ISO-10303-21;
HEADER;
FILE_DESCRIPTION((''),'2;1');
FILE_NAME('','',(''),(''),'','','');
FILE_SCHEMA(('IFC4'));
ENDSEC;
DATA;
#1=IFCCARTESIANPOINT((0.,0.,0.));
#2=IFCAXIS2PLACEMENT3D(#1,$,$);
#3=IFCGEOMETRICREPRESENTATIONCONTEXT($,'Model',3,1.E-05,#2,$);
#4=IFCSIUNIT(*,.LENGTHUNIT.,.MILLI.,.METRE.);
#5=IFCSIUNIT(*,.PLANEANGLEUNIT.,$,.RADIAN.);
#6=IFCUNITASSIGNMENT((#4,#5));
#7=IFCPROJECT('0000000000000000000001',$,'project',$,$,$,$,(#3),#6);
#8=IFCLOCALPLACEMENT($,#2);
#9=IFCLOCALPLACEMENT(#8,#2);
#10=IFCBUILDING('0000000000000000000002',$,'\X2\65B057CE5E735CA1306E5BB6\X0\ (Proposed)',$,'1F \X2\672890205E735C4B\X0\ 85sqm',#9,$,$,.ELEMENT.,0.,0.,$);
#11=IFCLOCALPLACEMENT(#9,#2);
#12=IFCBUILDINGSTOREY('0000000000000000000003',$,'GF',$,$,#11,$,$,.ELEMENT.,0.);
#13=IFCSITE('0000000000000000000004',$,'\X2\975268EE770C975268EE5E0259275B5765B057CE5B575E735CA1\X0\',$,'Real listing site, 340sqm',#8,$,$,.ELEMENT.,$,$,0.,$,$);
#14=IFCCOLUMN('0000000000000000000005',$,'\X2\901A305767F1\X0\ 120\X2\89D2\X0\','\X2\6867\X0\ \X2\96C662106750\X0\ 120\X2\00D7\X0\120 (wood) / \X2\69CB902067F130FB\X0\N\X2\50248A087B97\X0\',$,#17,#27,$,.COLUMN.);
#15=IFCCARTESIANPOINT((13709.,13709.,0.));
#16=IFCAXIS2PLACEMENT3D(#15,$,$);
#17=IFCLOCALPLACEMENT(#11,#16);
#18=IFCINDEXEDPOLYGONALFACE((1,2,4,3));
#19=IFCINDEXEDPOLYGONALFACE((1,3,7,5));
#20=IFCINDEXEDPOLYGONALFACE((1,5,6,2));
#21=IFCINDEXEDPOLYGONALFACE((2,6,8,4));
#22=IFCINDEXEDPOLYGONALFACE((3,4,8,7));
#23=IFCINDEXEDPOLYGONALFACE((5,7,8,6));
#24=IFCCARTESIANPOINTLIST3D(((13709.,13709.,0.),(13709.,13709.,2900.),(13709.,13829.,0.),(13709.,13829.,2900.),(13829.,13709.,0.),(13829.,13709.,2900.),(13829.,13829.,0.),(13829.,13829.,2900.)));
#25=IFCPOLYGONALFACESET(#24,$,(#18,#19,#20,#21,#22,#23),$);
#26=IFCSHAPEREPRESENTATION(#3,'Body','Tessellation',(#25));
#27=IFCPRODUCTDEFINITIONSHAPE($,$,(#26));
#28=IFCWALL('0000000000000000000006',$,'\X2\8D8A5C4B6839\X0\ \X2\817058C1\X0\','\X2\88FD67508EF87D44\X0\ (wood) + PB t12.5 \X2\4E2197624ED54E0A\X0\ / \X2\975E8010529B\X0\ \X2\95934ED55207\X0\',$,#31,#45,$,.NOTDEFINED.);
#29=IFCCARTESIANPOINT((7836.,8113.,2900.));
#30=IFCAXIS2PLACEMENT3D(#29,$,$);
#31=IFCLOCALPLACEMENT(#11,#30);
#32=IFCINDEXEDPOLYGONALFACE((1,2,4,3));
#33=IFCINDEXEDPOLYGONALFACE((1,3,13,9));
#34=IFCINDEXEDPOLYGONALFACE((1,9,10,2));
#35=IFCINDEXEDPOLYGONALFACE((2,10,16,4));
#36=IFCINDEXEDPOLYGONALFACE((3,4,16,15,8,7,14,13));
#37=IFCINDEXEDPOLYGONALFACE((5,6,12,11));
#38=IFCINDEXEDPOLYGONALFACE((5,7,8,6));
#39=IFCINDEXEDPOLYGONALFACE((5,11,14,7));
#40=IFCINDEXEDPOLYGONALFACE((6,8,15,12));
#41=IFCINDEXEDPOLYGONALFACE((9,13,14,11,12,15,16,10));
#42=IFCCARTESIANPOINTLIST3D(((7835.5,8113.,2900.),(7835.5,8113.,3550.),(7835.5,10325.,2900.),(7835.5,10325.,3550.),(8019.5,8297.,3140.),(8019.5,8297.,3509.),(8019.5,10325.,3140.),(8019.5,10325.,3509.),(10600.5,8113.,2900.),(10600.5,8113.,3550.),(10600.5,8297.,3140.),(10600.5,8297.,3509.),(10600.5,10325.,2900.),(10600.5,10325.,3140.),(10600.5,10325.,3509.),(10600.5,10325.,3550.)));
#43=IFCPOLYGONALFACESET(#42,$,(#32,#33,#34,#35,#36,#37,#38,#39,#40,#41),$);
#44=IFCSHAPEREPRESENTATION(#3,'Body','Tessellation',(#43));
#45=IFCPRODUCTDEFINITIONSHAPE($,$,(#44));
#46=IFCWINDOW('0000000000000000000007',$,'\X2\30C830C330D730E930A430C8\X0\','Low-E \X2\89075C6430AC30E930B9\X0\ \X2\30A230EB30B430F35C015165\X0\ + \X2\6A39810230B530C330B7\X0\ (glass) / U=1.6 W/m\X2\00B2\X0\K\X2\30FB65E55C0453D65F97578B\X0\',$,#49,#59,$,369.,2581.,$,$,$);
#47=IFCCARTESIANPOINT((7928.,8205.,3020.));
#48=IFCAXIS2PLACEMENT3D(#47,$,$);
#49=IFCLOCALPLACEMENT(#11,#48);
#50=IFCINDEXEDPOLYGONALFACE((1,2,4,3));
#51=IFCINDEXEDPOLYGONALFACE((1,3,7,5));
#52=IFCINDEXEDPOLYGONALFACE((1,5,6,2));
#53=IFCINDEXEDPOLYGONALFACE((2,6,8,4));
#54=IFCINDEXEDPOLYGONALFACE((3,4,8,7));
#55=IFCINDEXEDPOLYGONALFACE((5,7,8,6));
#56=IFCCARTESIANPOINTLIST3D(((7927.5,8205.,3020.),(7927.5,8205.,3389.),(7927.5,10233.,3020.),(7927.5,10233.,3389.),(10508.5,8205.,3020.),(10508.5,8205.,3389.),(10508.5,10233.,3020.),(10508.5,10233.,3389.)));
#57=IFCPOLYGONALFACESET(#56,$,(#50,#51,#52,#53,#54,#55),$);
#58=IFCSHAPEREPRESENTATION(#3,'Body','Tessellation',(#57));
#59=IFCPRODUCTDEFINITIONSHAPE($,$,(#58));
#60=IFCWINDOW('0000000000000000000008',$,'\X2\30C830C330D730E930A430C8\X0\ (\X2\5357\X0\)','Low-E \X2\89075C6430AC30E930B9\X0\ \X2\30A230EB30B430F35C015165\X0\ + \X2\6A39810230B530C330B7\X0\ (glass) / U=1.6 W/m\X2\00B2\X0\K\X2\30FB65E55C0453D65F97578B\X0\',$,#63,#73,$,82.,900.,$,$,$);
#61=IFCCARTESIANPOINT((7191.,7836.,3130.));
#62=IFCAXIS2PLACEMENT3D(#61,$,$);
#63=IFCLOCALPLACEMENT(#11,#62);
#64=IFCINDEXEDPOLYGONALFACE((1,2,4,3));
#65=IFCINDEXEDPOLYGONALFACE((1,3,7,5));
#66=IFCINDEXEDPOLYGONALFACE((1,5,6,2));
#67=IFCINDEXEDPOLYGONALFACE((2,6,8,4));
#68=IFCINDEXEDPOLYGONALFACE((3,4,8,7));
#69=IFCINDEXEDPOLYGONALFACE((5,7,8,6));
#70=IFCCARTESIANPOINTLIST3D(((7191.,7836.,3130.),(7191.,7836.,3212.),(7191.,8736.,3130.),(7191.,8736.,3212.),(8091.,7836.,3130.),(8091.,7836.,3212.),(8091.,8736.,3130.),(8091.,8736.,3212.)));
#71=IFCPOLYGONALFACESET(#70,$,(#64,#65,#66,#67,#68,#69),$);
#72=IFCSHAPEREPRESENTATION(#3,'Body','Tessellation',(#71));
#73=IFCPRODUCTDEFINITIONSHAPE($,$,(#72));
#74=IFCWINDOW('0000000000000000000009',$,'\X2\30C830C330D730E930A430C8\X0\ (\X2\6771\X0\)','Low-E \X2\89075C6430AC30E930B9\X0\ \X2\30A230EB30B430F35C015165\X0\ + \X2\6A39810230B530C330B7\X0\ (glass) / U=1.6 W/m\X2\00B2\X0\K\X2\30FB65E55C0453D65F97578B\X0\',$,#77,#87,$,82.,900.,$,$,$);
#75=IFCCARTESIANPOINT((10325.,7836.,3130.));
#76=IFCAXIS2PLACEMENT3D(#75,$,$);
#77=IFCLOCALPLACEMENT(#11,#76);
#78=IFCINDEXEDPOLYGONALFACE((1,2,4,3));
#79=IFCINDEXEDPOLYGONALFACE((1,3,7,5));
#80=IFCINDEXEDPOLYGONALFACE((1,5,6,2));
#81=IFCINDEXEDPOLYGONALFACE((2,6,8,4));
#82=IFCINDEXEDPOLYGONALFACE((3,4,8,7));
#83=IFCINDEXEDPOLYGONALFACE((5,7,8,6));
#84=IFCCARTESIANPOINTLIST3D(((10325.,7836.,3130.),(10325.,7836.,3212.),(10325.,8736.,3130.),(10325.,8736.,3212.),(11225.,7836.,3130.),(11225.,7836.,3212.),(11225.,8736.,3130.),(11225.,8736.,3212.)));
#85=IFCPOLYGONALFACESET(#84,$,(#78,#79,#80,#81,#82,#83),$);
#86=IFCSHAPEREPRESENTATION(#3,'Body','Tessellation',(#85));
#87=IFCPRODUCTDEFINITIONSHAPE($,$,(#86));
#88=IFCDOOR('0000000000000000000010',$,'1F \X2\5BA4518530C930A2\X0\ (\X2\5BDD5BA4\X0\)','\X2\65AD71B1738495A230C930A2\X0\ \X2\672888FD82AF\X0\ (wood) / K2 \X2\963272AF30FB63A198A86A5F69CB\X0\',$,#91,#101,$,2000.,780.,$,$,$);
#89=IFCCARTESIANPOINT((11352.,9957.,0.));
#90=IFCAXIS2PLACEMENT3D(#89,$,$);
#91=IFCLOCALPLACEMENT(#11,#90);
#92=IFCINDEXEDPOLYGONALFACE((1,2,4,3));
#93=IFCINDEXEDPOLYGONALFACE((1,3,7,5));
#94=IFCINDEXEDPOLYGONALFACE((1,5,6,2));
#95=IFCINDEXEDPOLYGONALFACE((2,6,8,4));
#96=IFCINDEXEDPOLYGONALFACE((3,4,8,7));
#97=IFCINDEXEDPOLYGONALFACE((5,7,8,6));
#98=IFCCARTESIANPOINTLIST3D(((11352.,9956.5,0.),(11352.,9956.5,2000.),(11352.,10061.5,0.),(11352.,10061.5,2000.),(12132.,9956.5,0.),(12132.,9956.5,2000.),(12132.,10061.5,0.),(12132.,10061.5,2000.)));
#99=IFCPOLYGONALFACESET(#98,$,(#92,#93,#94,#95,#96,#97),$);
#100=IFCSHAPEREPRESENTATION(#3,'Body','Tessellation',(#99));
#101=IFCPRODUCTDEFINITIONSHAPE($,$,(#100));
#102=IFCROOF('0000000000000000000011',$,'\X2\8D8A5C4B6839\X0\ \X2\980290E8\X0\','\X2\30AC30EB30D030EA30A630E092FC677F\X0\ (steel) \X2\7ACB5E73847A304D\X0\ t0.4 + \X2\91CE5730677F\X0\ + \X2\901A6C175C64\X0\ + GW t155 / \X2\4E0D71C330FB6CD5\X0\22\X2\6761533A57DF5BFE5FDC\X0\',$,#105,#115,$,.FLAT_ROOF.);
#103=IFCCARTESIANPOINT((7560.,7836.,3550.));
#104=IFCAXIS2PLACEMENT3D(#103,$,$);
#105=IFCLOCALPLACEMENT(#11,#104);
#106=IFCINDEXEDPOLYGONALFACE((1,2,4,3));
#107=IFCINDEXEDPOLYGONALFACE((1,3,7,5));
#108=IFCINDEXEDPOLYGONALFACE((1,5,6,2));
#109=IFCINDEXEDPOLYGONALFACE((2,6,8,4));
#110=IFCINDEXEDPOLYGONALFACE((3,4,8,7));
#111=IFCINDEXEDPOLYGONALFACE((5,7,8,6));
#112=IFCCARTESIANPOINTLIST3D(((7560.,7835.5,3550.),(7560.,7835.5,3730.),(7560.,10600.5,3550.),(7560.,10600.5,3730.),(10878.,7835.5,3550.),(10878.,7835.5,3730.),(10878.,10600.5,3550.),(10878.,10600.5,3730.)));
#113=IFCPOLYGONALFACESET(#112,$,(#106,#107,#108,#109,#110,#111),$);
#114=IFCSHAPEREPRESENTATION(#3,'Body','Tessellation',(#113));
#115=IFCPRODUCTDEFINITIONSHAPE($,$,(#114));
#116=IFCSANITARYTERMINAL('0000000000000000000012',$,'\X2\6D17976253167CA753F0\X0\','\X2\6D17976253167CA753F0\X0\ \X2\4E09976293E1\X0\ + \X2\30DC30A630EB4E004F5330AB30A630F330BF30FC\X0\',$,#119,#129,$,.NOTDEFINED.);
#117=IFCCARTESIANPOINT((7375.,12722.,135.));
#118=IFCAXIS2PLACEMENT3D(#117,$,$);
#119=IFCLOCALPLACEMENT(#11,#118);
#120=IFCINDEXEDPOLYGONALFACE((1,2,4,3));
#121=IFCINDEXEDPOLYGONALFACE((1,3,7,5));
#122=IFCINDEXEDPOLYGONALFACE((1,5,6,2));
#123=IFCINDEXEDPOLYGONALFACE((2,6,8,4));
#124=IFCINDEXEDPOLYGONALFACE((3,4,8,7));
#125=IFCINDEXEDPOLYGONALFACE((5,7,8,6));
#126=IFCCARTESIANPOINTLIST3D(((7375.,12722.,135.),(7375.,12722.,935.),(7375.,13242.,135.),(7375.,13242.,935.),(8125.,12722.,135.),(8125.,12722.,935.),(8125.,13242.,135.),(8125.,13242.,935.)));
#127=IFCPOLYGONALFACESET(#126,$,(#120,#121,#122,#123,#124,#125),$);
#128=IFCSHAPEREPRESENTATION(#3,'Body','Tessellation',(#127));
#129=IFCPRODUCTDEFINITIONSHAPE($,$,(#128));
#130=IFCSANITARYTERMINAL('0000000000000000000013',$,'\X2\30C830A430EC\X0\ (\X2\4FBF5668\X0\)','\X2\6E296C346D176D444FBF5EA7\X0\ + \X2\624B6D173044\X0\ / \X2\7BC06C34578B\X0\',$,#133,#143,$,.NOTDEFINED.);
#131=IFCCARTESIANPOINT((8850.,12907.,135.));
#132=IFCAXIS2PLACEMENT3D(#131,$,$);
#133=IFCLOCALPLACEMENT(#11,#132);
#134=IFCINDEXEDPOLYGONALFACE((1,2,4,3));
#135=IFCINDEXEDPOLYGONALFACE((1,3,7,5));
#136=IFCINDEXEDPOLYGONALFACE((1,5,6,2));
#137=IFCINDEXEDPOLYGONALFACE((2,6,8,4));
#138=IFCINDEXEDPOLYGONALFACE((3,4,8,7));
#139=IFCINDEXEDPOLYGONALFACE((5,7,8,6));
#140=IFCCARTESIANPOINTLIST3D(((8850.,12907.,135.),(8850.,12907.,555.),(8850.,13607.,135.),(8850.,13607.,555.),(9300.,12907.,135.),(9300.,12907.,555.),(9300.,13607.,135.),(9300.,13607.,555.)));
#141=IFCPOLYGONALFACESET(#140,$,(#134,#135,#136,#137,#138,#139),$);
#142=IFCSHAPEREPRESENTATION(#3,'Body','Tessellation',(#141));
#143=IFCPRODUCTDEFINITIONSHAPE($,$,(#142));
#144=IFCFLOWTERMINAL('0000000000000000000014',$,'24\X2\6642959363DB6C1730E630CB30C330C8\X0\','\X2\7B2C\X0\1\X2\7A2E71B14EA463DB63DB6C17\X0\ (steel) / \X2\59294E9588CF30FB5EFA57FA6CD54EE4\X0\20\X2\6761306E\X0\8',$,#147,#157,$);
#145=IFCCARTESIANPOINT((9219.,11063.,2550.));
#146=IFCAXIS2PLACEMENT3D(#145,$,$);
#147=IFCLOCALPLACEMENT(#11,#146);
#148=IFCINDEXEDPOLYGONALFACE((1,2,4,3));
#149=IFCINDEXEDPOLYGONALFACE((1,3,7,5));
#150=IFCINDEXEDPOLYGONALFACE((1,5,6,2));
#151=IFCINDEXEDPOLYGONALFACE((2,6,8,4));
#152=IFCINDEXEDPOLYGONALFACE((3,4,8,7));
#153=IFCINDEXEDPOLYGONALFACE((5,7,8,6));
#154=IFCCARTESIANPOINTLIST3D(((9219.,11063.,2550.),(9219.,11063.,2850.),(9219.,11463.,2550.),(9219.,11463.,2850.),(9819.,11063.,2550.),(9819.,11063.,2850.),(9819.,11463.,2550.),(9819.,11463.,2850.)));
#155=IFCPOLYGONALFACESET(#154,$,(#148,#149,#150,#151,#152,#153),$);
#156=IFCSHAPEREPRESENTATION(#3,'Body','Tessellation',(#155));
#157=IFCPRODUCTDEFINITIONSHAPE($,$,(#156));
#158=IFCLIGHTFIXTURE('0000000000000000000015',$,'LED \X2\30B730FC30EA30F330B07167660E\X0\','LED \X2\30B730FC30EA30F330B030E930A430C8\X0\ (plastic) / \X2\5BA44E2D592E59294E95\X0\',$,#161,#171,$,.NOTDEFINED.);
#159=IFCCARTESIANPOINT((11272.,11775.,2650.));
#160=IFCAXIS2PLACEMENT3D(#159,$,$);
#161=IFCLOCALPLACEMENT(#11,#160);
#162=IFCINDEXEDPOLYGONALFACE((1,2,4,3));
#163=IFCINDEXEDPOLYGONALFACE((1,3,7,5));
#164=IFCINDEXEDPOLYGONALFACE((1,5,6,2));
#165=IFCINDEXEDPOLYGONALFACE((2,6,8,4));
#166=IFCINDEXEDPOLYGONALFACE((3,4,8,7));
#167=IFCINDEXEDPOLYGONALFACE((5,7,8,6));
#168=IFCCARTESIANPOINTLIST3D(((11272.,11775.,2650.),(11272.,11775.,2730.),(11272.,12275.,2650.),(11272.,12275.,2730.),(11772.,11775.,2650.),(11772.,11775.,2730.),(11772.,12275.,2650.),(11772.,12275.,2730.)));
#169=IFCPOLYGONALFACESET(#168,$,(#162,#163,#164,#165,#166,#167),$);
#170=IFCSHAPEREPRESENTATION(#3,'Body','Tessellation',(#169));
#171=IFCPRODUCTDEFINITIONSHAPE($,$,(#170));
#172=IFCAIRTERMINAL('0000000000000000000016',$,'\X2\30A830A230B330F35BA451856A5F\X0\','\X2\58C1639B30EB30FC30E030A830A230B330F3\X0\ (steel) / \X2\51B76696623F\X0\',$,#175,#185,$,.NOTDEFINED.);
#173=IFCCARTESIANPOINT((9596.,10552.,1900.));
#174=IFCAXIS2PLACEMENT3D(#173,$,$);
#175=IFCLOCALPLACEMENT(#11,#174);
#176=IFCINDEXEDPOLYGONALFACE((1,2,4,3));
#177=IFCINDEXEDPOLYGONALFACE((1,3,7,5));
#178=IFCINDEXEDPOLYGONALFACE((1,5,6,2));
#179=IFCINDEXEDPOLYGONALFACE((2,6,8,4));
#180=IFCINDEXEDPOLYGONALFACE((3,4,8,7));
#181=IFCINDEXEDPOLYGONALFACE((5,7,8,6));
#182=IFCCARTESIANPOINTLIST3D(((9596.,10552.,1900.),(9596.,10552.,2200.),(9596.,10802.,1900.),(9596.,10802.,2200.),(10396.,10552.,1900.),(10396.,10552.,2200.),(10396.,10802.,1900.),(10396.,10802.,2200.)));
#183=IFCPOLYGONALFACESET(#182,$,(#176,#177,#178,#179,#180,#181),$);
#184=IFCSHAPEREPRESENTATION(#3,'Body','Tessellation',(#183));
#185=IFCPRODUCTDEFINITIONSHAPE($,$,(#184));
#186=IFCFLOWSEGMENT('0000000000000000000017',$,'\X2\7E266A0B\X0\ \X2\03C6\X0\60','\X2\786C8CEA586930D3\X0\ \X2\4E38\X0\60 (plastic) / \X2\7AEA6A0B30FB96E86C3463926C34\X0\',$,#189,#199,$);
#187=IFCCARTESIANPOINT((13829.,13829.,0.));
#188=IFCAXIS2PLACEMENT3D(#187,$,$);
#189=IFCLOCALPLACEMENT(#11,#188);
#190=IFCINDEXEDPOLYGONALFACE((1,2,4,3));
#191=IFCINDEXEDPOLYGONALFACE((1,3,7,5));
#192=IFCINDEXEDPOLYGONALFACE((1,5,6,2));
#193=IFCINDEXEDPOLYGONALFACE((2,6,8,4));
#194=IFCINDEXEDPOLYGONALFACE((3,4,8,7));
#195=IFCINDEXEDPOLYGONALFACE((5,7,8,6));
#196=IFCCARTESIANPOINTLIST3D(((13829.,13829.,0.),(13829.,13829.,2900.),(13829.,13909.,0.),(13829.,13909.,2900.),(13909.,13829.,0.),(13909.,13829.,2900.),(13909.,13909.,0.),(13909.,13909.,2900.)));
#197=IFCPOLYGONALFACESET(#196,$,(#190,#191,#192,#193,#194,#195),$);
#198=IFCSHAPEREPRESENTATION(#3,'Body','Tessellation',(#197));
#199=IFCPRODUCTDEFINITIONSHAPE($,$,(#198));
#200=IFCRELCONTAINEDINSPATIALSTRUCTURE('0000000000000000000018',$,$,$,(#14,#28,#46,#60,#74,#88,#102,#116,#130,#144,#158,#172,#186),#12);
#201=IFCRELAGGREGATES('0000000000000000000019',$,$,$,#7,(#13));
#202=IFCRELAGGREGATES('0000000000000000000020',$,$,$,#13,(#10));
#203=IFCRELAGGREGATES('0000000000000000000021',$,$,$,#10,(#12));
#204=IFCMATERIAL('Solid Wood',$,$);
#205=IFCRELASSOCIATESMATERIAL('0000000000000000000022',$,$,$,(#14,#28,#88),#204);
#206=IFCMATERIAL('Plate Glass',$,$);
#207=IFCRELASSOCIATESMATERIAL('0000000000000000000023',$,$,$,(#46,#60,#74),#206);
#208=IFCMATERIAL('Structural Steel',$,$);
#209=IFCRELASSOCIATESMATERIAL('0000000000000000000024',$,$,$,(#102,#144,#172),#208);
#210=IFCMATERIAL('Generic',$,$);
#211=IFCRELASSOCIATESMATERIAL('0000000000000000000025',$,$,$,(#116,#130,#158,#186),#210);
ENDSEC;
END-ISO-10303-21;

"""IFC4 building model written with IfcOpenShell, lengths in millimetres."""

from ifc_helpers import new_model, si_unit, frame, frame_2d, origin, place, context, project, spatial, rectangle, extrude, material, element, fill, save


model = new_model("IFC4")

# Units and contexts
model_context = context("Model", 3, precision=1e-05, world=origin())
ifc_project = project(units=[si_unit("LENGTHUNIT", "METRE", prefix="MILLI"), si_unit("PLANEANGLEUNIT", "RADIAN")], contexts=[model_context])

# Site, building, storey
site_placement = place(None, origin())
site = spatial("IfcSite", under=ifc_project, at=site_placement, Name="青森県青森市大字新城字平岡", ObjectType="Real listing site, 340sqm", CompositionType="ELEMENT", RefElevation=0.0)
building_placement = place(site_placement, origin())
building = spatial("IfcBuilding", under=site, at=building_placement, Name="新城平岡の家 (Proposed)", ObjectType="1F 木造平屋 85sqm", CompositionType="ELEMENT", ElevationOfRefHeight=0.0, ElevationOfTerrain=0.0)
storey_placement = place(building_placement, origin())
storey = spatial("IfcBuildingStorey", under=building, at=storey_placement, Name="GF", CompositionType="ELEMENT", Elevation=0.0)

# Column
ifc_material_1 = material(Name="Solid Wood")
column_1_placement = place(storey_placement, frame((13709.0, 13709.0, 0.0)))
element("IfcColumn", 1, at=column_1_placement, inside=storey, material=ifc_material_1, Name="通し柱 120角", Description="桧 集成材 120×120 (wood) / 構造柱・N値計算", PredefinedType="COLUMN", context=model_context, shape_type="SweptSolid", body=[
    extrude(rectangle(XDim=120.0, YDim=120.0, at=frame_2d((60.0, 60.0))), frame((13709.0, 13709.0, 0.0)), (0.0, 0.0, 1.0), 2900.0),
])

# Wall, openings, windows
wall_1_placement = place(storey_placement, frame((7836.0, 8113.0, 2900.0)))
wall_1 = element("IfcWall", 2, at=wall_1_placement, inside=storey, material=ifc_material_1, Name="越屋根 腰壁", Description="製材軸組 (wood) + PB t12.5 両面仕上 / 非耐力 間仕切", PredefinedType="NOTDEFINED", context=model_context, shape_type="SweptSolid", body=[
    extrude(rectangle(XDim=2765.0, YDim=2212.0, at=frame_2d((1382.0, 1106.0))), frame((7836.0, 8113.0, 2900.0)), (0.0, 0.0, 1.0), 650.0),
])
opening_1_placement = place(storey_placement, frame((7928.0, 8205.0, 3020.0)))
opening_1 = element("IfcOpeningElement", 3, at=opening_1_placement, cuts=wall_1, PredefinedType="NOTDEFINED", context=model_context, shape_type="SweptSolid", body=[
    extrude(rectangle(XDim=2581.0, YDim=2028.0, at=frame_2d((1290.0, 1014.0))), frame((7928.0, 8205.0, 3020.0)), (0.0, 0.0, 1.0), 369.0),
])
opening_2_placement = place(storey_placement, frame((7191.0, 7836.0, 3130.0)))
opening_2 = element("IfcOpeningElement", 4, at=opening_2_placement, cuts=wall_1, PredefinedType="NOTDEFINED", context=model_context, shape_type="SweptSolid", body=[
    extrude(rectangle(XDim=900.0, YDim=900.0, at=frame_2d((450.0, 450.0))), frame((7191.0, 7836.0, 3130.0)), (0.0, 0.0, 1.0), 82.0),
])
opening_3_placement = place(storey_placement, frame((10325.0, 7836.0, 3130.0)))
opening_3 = element("IfcOpeningElement", 5, at=opening_3_placement, cuts=wall_1, PredefinedType="NOTDEFINED", context=model_context, shape_type="SweptSolid", body=[
    extrude(rectangle(XDim=900.0, YDim=900.0, at=frame_2d((450.0, 450.0))), frame((10325.0, 7836.0, 3130.0)), (0.0, 0.0, 1.0), 82.0),
])
ifc_material_2 = material(Name="Plate Glass")
window_1_placement = place(storey_placement, frame((7928.0, 8205.0, 3020.0)))
window_1 = element("IfcWindow", 6, at=window_1_placement, inside=storey, material=ifc_material_2, Name="トップライト", Description="Low-E 複層ガラス アルゴン封入 + 樹脂サッシ (glass) / U=1.6 W/m²K・日射取得型", OverallHeight=369.0, OverallWidth=2581.0, context=model_context, shape_type="SweptSolid", body=[
    extrude(rectangle(XDim=2581.0, YDim=2028.0, at=frame_2d((1290.0, 1014.0))), frame((7928.0, 8205.0, 3020.0)), (0.0, 0.0, 1.0), 369.0),
])
fill(opening_1, window_1)
window_2_placement = place(storey_placement, frame((7191.0, 7836.0, 3130.0)))
window_2 = element("IfcWindow", 7, at=window_2_placement, inside=storey, material=ifc_material_2, Name="トップライト (南)", Description="Low-E 複層ガラス アルゴン封入 + 樹脂サッシ (glass) / U=1.6 W/m²K・日射取得型", OverallHeight=82.0, OverallWidth=900.0, context=model_context, shape_type="SweptSolid", body=[
    extrude(rectangle(XDim=900.0, YDim=900.0, at=frame_2d((450.0, 450.0))), frame((7191.0, 7836.0, 3130.0)), (0.0, 0.0, 1.0), 82.0),
])
fill(opening_2, window_2)
window_3_placement = place(storey_placement, frame((10325.0, 7836.0, 3130.0)))
window_3 = element("IfcWindow", 8, at=window_3_placement, inside=storey, material=ifc_material_2, Name="トップライト (東)", Description="Low-E 複層ガラス アルゴン封入 + 樹脂サッシ (glass) / U=1.6 W/m²K・日射取得型", OverallHeight=82.0, OverallWidth=900.0, context=model_context, shape_type="SweptSolid", body=[
    extrude(rectangle(XDim=900.0, YDim=900.0, at=frame_2d((450.0, 450.0))), frame((10325.0, 7836.0, 3130.0)), (0.0, 0.0, 1.0), 82.0),
])
fill(opening_3, window_3)

# Door
door_placement = place(storey_placement, frame((11352.0, 9957.0, 0.0)))
element("IfcDoor", 9, at=door_placement, inside=storey, material=ifc_material_1, Name="1F 室内ドア (寝室)", Description="断熱玄関ドア 木製芯 (wood) / K2 防犯・採風機構", OverallHeight=2000.0, OverallWidth=780.0, context=model_context, shape_type="SweptSolid", body=[
    extrude(rectangle(XDim=780.0, YDim=105.0, at=frame_2d((390.0, 52.0))), frame((11352.0, 9957.0, 0.0)), (0.0, 0.0, 1.0), 2000.0),
])

# Roof
ifc_material_3 = material(Name="Structural Steel")
roof_placement = place(storey_placement, frame((7560.0, 7836.0, 3550.0)))
element("IfcRoof", 10, at=roof_placement, inside=storey, material=ifc_material_3, Name="越屋根 頂部", Description="ガルバリウム鋼板 (steel) 立平葺き t0.4 + 野地板 + 通気層 + GW t155 / 不燃・法22条区域対応", PredefinedType="FLAT_ROOF", context=model_context, shape_type="SweptSolid", body=[
    extrude(rectangle(XDim=3318.0, YDim=2765.0, at=frame_2d((1659.0, 1382.0))), frame((7560.0, 7836.0, 3550.0)), (0.0, 0.0, 1.0), 180.0),
])

# Sanitary terminals
ifc_material_4 = material(Name="Generic")
sanitary_terminal_1_placement = place(storey_placement, frame((7375.0, 12722.0, 135.0)))
element("IfcSanitaryTerminal", 11, at=sanitary_terminal_1_placement, inside=storey, material=ifc_material_4, Name="洗面化粧台", Description="洗面化粧台 三面鏡 + ボウル一体カウンター", PredefinedType="NOTDEFINED", context=model_context, shape_type="SweptSolid", body=[
    extrude(rectangle(XDim=750.0, YDim=520.0, at=frame_2d((375.0, 260.0))), frame((7375.0, 12722.0, 135.0)), (0.0, 0.0, 1.0), 800.0),
])
sanitary_terminal_2_placement = place(storey_placement, frame((8850.0, 12907.0, 135.0)))
element("IfcSanitaryTerminal", 12, at=sanitary_terminal_2_placement, inside=storey, material=ifc_material_4, Name="トイレ (便器)", Description="温水洗浄便座 + 手洗い / 節水型", PredefinedType="NOTDEFINED", context=model_context, shape_type="SweptSolid", body=[
    extrude(rectangle(XDim=450.0, YDim=700.0, at=frame_2d((225.0, 350.0))), frame((8850.0, 12907.0, 135.0)), (0.0, 0.0, 1.0), 420.0),
])

# Flow terminal
flow_terminal_placement = place(storey_placement, frame((9219.0, 11063.0, 2550.0)))
element("IfcFlowTerminal", 13, at=flow_terminal_placement, inside=storey, material=ifc_material_3, Name="24時間換気ユニット", Description="第1種熱交換換気 (steel) / 天井裏・建基法令20条の8", context=model_context, shape_type="SweptSolid", body=[
    extrude(rectangle(XDim=600.0, YDim=400.0, at=frame_2d((300.0, 200.0))), frame((9219.0, 11063.0, 2550.0)), (0.0, 0.0, 1.0), 300.0),
])

# Light fixture
light_fixture_placement = place(storey_placement, frame((11272.0, 11775.0, 2650.0)))
element("IfcLightFixture", 14, at=light_fixture_placement, inside=storey, material=ifc_material_4, Name="LED シーリング照明", Description="LED シーリングライト (plastic) / 室中央天井", PredefinedType="NOTDEFINED", context=model_context, shape_type="SweptSolid", body=[
    extrude(rectangle(XDim=500.0, YDim=500.0, at=frame_2d((250.0, 250.0))), frame((11272.0, 11775.0, 2650.0)), (0.0, 0.0, 1.0), 80.0),
])

# Air terminal
air_terminal_placement = place(storey_placement, frame((9596.0, 10552.0, 1900.0)))
element("IfcAirTerminal", 15, at=air_terminal_placement, inside=storey, material=ifc_material_3, Name="エアコン室内機", Description="壁掛ルームエアコン (steel) / 冷暖房", PredefinedType="NOTDEFINED", context=model_context, shape_type="SweptSolid", body=[
    extrude(rectangle(XDim=800.0, YDim=250.0, at=frame_2d((400.0, 125.0))), frame((9596.0, 10552.0, 1900.0)), (0.0, 0.0, 1.0), 300.0),
])

# Flow segment
flow_segment_placement = place(storey_placement, frame((13829.0, 13829.0, 0.0)))
element("IfcFlowSegment", 16, at=flow_segment_placement, inside=storey, material=ifc_material_4, Name="縦樋 φ60", Description="硬質塩ビ 丸60 (plastic) / 竪樋・雨水排水", context=model_context, shape_type="SweptSolid", body=[
    extrude(rectangle(XDim=80.0, YDim=80.0, at=frame_2d((40.0, 40.0))), frame((13829.0, 13829.0, 0.0)), (0.0, 0.0, 1.0), 2900.0),
])

save(model, "model.ifc")
